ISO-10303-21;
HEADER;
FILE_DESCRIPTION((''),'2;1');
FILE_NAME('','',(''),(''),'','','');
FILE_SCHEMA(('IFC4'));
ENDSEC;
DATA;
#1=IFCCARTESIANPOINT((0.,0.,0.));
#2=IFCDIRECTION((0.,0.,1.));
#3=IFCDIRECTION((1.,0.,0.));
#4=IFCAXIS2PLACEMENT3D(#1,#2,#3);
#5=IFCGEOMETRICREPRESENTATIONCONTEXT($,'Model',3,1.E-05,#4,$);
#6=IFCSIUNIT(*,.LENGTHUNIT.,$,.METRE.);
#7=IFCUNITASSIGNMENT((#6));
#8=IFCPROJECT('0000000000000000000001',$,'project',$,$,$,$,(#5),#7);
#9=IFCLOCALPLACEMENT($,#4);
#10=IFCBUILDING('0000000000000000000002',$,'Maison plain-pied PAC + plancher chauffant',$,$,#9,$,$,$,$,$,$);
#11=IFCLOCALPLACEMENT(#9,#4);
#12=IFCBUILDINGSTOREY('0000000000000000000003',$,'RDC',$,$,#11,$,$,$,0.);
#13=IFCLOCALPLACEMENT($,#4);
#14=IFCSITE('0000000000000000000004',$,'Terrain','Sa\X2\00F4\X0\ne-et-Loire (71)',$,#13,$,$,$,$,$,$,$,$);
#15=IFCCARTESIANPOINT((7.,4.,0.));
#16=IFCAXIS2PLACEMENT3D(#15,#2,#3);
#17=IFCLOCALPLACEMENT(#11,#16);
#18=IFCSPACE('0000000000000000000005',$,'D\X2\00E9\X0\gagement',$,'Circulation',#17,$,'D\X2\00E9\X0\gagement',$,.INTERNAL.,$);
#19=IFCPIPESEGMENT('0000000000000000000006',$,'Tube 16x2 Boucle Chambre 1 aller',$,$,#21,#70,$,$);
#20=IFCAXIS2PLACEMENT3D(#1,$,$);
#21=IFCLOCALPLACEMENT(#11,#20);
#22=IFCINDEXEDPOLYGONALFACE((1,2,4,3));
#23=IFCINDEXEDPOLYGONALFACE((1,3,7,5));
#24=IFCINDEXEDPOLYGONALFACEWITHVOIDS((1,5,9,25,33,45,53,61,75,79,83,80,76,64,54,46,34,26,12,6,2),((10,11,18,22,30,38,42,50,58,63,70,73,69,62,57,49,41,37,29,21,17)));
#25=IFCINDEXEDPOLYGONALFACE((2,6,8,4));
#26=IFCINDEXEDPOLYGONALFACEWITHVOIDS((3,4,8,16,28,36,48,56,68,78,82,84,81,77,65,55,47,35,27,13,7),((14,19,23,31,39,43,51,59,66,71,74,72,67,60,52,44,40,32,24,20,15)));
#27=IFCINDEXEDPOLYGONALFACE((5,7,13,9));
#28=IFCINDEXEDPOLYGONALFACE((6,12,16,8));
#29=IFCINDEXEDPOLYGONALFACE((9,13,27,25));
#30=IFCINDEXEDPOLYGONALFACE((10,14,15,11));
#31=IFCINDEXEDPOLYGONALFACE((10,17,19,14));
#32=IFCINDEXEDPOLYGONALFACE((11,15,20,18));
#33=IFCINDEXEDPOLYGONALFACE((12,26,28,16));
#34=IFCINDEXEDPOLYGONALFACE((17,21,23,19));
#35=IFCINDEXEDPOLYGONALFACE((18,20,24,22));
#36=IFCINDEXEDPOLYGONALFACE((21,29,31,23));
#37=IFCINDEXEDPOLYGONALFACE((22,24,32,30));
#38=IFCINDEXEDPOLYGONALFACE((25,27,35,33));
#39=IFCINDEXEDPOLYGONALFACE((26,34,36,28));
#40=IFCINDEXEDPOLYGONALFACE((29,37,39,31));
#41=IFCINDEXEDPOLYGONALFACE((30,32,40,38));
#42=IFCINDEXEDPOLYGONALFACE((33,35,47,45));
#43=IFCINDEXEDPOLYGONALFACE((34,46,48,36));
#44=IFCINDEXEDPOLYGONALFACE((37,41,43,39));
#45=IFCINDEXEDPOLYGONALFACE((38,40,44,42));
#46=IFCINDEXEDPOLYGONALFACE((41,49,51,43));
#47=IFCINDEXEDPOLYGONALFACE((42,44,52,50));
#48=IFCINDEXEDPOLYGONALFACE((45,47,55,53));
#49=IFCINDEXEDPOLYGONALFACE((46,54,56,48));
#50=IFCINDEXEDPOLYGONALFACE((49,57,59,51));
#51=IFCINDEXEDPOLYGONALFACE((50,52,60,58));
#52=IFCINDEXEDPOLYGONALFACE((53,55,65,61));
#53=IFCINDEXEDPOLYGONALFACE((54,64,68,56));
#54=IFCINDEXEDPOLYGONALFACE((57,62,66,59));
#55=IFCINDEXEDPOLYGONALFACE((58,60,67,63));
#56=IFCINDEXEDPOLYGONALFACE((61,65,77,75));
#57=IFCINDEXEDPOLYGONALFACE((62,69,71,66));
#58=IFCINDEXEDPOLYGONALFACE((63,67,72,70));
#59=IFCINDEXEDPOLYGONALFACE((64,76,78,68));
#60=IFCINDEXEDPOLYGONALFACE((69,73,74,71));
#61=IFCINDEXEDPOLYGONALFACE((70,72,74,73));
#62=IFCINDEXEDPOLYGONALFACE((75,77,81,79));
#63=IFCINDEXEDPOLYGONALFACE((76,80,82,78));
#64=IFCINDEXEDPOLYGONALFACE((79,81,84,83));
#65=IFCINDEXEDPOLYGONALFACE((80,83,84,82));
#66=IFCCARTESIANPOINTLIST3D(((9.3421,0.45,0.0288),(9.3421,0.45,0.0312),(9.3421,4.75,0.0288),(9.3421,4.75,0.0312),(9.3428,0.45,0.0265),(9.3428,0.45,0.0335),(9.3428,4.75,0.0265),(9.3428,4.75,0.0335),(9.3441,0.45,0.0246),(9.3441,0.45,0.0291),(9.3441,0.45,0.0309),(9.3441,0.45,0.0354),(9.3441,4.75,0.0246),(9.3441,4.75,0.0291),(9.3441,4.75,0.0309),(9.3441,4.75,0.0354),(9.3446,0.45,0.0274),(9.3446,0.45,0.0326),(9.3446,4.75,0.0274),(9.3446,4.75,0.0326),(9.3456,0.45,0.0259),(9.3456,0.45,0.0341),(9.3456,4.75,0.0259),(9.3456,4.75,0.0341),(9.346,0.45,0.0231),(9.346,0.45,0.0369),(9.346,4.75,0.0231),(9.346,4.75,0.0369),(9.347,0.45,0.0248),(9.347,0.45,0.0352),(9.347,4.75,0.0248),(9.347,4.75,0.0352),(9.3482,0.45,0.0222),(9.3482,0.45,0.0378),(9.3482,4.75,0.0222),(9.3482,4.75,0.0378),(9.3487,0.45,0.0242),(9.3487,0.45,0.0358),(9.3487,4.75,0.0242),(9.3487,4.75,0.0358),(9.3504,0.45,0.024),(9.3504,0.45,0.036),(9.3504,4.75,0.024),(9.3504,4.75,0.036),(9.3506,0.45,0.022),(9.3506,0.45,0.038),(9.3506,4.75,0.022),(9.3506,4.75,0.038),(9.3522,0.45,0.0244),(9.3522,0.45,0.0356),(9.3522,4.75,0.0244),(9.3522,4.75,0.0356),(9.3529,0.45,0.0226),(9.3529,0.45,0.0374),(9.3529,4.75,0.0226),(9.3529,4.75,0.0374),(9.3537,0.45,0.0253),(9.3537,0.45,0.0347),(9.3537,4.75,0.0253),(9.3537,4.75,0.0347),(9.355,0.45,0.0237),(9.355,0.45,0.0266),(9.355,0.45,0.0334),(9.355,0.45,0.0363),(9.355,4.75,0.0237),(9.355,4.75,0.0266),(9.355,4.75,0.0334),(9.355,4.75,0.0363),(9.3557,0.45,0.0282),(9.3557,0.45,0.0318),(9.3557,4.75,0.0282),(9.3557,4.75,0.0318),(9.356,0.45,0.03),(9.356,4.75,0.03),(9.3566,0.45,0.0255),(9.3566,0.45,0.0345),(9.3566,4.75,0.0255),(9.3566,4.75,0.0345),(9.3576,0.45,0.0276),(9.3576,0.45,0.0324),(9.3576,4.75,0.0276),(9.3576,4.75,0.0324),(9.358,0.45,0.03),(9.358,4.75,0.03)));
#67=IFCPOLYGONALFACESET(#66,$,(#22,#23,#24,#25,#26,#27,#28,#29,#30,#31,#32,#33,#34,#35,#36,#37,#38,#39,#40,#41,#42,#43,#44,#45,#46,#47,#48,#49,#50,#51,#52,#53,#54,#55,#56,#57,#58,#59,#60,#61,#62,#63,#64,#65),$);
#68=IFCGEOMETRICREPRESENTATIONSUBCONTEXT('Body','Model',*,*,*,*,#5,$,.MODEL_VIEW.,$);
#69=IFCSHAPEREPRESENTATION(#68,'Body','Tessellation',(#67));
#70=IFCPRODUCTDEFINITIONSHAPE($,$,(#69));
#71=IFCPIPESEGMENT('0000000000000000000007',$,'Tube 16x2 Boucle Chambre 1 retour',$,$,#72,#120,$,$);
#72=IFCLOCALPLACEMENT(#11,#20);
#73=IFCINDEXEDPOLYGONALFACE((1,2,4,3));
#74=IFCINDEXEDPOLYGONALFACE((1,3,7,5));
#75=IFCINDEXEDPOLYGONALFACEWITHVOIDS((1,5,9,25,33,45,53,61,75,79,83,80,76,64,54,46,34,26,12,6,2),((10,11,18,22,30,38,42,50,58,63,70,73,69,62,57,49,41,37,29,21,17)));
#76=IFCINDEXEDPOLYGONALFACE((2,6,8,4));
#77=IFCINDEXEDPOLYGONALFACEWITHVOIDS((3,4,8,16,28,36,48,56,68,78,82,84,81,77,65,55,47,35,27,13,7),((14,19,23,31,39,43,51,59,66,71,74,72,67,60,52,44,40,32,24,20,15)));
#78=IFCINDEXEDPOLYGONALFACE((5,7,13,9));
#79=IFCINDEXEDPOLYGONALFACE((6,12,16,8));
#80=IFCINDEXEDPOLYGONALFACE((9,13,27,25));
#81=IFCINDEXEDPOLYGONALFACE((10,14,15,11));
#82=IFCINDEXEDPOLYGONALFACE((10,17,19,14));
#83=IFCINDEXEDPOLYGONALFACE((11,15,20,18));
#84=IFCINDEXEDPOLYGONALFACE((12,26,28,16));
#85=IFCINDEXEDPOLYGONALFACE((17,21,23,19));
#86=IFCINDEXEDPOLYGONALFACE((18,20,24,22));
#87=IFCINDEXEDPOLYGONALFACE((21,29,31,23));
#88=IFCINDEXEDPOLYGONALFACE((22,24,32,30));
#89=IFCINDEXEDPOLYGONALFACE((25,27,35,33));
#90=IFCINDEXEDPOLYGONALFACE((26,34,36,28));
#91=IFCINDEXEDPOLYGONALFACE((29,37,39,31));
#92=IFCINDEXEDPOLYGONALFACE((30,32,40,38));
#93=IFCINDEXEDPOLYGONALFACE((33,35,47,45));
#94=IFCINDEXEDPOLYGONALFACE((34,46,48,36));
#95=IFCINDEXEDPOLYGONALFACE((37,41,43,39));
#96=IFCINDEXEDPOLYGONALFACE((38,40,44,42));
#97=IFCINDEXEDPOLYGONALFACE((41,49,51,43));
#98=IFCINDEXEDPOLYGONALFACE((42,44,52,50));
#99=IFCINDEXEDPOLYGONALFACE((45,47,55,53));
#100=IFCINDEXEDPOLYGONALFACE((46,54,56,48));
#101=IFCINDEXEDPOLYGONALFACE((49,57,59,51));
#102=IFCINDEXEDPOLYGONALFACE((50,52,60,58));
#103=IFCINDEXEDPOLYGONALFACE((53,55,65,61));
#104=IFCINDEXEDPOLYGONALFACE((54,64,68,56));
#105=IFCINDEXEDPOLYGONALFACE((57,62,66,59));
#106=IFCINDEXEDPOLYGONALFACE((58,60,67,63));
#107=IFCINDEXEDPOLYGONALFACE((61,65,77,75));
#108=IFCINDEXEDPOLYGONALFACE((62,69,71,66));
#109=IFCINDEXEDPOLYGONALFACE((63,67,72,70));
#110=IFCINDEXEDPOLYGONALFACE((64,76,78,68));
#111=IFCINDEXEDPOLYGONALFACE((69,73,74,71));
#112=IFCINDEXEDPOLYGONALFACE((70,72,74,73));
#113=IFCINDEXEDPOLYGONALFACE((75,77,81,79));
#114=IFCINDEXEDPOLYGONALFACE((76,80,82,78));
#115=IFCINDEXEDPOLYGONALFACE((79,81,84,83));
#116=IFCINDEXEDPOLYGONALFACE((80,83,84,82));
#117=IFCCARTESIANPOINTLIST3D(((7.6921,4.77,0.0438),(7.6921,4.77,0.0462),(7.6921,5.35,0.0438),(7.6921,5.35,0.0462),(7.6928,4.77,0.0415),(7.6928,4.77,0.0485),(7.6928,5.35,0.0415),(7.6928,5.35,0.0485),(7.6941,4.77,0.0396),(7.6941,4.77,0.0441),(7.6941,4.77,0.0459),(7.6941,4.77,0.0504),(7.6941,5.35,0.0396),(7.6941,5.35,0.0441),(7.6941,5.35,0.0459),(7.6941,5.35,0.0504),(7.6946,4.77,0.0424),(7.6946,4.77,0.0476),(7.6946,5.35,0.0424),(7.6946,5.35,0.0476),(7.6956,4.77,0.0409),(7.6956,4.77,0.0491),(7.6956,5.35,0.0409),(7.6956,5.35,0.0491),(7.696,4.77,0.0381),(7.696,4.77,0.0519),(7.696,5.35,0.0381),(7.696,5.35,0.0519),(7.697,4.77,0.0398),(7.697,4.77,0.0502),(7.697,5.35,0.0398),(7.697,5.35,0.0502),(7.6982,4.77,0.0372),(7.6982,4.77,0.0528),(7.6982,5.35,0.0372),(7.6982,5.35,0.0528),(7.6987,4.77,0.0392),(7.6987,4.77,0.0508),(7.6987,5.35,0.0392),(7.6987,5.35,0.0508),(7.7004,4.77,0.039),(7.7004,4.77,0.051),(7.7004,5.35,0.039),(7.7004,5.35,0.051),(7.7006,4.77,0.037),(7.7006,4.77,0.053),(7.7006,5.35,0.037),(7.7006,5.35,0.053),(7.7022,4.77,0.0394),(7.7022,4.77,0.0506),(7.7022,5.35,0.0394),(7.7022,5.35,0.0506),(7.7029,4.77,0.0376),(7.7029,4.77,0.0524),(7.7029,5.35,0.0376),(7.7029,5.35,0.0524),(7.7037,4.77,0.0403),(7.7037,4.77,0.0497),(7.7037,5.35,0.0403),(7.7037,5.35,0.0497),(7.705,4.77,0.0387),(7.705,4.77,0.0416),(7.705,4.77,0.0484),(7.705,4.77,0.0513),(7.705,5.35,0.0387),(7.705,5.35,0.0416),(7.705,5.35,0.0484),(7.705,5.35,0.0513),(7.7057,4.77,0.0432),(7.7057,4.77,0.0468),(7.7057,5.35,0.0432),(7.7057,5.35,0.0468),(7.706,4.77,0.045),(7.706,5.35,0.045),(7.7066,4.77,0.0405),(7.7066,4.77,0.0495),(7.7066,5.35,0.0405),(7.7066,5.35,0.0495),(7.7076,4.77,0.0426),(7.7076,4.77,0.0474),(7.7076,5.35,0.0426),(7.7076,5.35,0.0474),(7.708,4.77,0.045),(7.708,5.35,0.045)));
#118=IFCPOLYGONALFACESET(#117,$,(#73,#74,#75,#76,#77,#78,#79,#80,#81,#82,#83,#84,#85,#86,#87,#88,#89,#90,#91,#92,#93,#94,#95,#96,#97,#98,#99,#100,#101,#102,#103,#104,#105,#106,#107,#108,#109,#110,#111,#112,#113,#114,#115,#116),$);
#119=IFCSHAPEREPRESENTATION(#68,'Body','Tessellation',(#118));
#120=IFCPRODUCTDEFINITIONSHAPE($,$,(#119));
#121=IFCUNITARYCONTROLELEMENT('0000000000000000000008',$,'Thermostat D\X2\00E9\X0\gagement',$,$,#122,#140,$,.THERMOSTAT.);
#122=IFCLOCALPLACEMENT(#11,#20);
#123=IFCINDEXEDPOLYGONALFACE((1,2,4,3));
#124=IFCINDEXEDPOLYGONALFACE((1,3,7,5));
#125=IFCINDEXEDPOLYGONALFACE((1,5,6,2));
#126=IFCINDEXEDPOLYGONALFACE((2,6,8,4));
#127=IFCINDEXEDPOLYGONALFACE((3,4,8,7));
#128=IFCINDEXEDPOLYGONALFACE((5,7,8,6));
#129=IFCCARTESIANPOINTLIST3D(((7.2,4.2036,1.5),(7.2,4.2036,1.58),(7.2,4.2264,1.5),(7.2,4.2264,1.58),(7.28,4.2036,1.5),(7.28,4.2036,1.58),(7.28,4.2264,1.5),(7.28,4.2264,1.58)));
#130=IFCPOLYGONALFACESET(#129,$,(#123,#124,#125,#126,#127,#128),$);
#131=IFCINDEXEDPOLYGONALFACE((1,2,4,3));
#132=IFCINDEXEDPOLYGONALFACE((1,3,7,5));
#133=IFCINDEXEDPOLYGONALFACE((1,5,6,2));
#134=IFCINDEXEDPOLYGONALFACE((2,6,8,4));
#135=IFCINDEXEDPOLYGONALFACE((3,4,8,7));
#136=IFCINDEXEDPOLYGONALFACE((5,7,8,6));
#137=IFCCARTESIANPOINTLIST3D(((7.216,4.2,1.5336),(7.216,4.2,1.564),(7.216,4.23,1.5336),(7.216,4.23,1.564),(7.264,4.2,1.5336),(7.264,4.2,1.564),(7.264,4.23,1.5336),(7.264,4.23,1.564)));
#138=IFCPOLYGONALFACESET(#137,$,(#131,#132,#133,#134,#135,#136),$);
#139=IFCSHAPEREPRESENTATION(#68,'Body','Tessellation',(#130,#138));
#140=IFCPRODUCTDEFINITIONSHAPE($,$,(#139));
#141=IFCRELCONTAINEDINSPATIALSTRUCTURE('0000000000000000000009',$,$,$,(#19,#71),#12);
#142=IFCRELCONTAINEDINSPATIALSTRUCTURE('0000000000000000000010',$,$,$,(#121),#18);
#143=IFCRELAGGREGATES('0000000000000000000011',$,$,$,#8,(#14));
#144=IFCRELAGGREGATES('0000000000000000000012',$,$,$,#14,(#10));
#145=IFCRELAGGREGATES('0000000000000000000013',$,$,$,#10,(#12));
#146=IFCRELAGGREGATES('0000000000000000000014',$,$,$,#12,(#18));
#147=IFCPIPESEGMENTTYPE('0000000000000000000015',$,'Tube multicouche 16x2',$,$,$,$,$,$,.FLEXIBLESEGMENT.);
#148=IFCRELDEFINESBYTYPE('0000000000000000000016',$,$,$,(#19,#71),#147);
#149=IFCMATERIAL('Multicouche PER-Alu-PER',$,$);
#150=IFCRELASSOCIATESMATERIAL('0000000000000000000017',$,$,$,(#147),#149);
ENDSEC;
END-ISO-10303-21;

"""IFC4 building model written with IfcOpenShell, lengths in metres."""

from ifc_helpers import new_model, si_unit, frame, frame_2d, origin_with_axes, place, context, subcontext, project, spatial, rectangle, hollow_circle, extrude, material, type_object, element, save


model = new_model("IFC4")

# Units and contexts
model_context = context("Model", 3, precision=1e-05, world=origin_with_axes())
body_context = subcontext(model_context, "Body", "Model", "MODEL_VIEW")
ifc_project = project(units=[si_unit("LENGTHUNIT", "METRE")], contexts=[model_context])

# Site, building, storey
site_placement = place(None, origin_with_axes())
site = spatial("IfcSite", under=ifc_project, at=site_placement, Name="Terrain", Description="Saône-et-Loire (71)")
building_placement = place(None, origin_with_axes())
building = spatial("IfcBuilding", under=site, at=building_placement, Name="Maison plain-pied PAC + plancher chauffant")
storey_placement = place(building_placement, origin_with_axes())
storey = spatial("IfcBuildingStorey", under=building, at=storey_placement, Name="RDC", Elevation=0.0)

# Pipe segments
ifc_material = material(Name="Multicouche PER-Alu-PER")
pipe_segment_type = type_object("IfcPipeSegmentType", Name="Tube multicouche 16x2", PredefinedType="FLEXIBLESEGMENT", material=ifc_material)
pipe_segment_1_placement = place(storey_placement, frame((9.35, 4.75, 0.03), z_axis=(0.0, -1.0, 0.0), x_axis=(1.0, 0.0, 0.0)))
element("IfcPipeSegment", 1, at=pipe_segment_1_placement, inside=storey, type_object=pipe_segment_type, Name="Tube 16x2 Boucle Chambre 1 aller", context=body_context, shape_type="SweptSolid", body=[
    extrude(hollow_circle(Radius=0.008, WallThickness=0.002), origin_with_axes(), (0.0, 0.0, 1.0), 4.3),
])
pipe_segment_2_placement = place(storey_placement, frame((7.7, 4.77, 0.045), z_axis=(0.0, 1.0, 0.0), x_axis=(1.0, 0.0, 0.0)))
element("IfcPipeSegment", 2, at=pipe_segment_2_placement, inside=storey, type_object=pipe_segment_type, Name="Tube 16x2 Boucle Chambre 1 retour", context=body_context, shape_type="SweptSolid", body=[
    extrude(hollow_circle(Radius=0.008, WallThickness=0.002), origin_with_axes(), (0.0, 0.0, 1.0), 0.58),
])

# Shared definitions
space_placement = place(storey_placement, frame((7.0, 4.0, 0.0), z_axis=(0.0, 0.0, 1.0), x_axis=(1.0, 0.0, 0.0)))
space = spatial("IfcSpace", under=storey, at=space_placement, Name="Dégagement", ObjectType="Circulation", LongName="Dégagement", PredefinedType="INTERNAL")

# Unitary control element
unitary_control_element_placement = place(space_placement, frame((0.2, 0.2, 1.5), z_axis=(0.0, 0.0, 1.0), x_axis=(1.0, 0.0, 0.0)))
element("IfcUnitaryControlElement", 3, at=unitary_control_element_placement, inside=space, Name="Thermostat Dégagement", PredefinedType="THERMOSTAT", context=body_context, shape_type="SweptSolid", body=[
    extrude(rectangle(XDim=0.08, YDim=0.0228, at=frame_2d((0.04, 0.0114))), frame((0.0, 0.0036, 0.0), z_axis=(0.0, 0.0, 1.0), x_axis=(1.0, 0.0, 0.0)), (0.0, 0.0, 1.0), 0.08),
    extrude(rectangle(XDim=0.048, YDim=0.03, at=frame_2d((0.024, 0.015))), frame((0.016, 0.0, 0.0336), z_axis=(0.0, 0.0, 1.0), x_axis=(1.0, 0.0, 0.0)), (0.0, 0.0, 1.0), 0.0304),
])

save(model, "model.ifc")
